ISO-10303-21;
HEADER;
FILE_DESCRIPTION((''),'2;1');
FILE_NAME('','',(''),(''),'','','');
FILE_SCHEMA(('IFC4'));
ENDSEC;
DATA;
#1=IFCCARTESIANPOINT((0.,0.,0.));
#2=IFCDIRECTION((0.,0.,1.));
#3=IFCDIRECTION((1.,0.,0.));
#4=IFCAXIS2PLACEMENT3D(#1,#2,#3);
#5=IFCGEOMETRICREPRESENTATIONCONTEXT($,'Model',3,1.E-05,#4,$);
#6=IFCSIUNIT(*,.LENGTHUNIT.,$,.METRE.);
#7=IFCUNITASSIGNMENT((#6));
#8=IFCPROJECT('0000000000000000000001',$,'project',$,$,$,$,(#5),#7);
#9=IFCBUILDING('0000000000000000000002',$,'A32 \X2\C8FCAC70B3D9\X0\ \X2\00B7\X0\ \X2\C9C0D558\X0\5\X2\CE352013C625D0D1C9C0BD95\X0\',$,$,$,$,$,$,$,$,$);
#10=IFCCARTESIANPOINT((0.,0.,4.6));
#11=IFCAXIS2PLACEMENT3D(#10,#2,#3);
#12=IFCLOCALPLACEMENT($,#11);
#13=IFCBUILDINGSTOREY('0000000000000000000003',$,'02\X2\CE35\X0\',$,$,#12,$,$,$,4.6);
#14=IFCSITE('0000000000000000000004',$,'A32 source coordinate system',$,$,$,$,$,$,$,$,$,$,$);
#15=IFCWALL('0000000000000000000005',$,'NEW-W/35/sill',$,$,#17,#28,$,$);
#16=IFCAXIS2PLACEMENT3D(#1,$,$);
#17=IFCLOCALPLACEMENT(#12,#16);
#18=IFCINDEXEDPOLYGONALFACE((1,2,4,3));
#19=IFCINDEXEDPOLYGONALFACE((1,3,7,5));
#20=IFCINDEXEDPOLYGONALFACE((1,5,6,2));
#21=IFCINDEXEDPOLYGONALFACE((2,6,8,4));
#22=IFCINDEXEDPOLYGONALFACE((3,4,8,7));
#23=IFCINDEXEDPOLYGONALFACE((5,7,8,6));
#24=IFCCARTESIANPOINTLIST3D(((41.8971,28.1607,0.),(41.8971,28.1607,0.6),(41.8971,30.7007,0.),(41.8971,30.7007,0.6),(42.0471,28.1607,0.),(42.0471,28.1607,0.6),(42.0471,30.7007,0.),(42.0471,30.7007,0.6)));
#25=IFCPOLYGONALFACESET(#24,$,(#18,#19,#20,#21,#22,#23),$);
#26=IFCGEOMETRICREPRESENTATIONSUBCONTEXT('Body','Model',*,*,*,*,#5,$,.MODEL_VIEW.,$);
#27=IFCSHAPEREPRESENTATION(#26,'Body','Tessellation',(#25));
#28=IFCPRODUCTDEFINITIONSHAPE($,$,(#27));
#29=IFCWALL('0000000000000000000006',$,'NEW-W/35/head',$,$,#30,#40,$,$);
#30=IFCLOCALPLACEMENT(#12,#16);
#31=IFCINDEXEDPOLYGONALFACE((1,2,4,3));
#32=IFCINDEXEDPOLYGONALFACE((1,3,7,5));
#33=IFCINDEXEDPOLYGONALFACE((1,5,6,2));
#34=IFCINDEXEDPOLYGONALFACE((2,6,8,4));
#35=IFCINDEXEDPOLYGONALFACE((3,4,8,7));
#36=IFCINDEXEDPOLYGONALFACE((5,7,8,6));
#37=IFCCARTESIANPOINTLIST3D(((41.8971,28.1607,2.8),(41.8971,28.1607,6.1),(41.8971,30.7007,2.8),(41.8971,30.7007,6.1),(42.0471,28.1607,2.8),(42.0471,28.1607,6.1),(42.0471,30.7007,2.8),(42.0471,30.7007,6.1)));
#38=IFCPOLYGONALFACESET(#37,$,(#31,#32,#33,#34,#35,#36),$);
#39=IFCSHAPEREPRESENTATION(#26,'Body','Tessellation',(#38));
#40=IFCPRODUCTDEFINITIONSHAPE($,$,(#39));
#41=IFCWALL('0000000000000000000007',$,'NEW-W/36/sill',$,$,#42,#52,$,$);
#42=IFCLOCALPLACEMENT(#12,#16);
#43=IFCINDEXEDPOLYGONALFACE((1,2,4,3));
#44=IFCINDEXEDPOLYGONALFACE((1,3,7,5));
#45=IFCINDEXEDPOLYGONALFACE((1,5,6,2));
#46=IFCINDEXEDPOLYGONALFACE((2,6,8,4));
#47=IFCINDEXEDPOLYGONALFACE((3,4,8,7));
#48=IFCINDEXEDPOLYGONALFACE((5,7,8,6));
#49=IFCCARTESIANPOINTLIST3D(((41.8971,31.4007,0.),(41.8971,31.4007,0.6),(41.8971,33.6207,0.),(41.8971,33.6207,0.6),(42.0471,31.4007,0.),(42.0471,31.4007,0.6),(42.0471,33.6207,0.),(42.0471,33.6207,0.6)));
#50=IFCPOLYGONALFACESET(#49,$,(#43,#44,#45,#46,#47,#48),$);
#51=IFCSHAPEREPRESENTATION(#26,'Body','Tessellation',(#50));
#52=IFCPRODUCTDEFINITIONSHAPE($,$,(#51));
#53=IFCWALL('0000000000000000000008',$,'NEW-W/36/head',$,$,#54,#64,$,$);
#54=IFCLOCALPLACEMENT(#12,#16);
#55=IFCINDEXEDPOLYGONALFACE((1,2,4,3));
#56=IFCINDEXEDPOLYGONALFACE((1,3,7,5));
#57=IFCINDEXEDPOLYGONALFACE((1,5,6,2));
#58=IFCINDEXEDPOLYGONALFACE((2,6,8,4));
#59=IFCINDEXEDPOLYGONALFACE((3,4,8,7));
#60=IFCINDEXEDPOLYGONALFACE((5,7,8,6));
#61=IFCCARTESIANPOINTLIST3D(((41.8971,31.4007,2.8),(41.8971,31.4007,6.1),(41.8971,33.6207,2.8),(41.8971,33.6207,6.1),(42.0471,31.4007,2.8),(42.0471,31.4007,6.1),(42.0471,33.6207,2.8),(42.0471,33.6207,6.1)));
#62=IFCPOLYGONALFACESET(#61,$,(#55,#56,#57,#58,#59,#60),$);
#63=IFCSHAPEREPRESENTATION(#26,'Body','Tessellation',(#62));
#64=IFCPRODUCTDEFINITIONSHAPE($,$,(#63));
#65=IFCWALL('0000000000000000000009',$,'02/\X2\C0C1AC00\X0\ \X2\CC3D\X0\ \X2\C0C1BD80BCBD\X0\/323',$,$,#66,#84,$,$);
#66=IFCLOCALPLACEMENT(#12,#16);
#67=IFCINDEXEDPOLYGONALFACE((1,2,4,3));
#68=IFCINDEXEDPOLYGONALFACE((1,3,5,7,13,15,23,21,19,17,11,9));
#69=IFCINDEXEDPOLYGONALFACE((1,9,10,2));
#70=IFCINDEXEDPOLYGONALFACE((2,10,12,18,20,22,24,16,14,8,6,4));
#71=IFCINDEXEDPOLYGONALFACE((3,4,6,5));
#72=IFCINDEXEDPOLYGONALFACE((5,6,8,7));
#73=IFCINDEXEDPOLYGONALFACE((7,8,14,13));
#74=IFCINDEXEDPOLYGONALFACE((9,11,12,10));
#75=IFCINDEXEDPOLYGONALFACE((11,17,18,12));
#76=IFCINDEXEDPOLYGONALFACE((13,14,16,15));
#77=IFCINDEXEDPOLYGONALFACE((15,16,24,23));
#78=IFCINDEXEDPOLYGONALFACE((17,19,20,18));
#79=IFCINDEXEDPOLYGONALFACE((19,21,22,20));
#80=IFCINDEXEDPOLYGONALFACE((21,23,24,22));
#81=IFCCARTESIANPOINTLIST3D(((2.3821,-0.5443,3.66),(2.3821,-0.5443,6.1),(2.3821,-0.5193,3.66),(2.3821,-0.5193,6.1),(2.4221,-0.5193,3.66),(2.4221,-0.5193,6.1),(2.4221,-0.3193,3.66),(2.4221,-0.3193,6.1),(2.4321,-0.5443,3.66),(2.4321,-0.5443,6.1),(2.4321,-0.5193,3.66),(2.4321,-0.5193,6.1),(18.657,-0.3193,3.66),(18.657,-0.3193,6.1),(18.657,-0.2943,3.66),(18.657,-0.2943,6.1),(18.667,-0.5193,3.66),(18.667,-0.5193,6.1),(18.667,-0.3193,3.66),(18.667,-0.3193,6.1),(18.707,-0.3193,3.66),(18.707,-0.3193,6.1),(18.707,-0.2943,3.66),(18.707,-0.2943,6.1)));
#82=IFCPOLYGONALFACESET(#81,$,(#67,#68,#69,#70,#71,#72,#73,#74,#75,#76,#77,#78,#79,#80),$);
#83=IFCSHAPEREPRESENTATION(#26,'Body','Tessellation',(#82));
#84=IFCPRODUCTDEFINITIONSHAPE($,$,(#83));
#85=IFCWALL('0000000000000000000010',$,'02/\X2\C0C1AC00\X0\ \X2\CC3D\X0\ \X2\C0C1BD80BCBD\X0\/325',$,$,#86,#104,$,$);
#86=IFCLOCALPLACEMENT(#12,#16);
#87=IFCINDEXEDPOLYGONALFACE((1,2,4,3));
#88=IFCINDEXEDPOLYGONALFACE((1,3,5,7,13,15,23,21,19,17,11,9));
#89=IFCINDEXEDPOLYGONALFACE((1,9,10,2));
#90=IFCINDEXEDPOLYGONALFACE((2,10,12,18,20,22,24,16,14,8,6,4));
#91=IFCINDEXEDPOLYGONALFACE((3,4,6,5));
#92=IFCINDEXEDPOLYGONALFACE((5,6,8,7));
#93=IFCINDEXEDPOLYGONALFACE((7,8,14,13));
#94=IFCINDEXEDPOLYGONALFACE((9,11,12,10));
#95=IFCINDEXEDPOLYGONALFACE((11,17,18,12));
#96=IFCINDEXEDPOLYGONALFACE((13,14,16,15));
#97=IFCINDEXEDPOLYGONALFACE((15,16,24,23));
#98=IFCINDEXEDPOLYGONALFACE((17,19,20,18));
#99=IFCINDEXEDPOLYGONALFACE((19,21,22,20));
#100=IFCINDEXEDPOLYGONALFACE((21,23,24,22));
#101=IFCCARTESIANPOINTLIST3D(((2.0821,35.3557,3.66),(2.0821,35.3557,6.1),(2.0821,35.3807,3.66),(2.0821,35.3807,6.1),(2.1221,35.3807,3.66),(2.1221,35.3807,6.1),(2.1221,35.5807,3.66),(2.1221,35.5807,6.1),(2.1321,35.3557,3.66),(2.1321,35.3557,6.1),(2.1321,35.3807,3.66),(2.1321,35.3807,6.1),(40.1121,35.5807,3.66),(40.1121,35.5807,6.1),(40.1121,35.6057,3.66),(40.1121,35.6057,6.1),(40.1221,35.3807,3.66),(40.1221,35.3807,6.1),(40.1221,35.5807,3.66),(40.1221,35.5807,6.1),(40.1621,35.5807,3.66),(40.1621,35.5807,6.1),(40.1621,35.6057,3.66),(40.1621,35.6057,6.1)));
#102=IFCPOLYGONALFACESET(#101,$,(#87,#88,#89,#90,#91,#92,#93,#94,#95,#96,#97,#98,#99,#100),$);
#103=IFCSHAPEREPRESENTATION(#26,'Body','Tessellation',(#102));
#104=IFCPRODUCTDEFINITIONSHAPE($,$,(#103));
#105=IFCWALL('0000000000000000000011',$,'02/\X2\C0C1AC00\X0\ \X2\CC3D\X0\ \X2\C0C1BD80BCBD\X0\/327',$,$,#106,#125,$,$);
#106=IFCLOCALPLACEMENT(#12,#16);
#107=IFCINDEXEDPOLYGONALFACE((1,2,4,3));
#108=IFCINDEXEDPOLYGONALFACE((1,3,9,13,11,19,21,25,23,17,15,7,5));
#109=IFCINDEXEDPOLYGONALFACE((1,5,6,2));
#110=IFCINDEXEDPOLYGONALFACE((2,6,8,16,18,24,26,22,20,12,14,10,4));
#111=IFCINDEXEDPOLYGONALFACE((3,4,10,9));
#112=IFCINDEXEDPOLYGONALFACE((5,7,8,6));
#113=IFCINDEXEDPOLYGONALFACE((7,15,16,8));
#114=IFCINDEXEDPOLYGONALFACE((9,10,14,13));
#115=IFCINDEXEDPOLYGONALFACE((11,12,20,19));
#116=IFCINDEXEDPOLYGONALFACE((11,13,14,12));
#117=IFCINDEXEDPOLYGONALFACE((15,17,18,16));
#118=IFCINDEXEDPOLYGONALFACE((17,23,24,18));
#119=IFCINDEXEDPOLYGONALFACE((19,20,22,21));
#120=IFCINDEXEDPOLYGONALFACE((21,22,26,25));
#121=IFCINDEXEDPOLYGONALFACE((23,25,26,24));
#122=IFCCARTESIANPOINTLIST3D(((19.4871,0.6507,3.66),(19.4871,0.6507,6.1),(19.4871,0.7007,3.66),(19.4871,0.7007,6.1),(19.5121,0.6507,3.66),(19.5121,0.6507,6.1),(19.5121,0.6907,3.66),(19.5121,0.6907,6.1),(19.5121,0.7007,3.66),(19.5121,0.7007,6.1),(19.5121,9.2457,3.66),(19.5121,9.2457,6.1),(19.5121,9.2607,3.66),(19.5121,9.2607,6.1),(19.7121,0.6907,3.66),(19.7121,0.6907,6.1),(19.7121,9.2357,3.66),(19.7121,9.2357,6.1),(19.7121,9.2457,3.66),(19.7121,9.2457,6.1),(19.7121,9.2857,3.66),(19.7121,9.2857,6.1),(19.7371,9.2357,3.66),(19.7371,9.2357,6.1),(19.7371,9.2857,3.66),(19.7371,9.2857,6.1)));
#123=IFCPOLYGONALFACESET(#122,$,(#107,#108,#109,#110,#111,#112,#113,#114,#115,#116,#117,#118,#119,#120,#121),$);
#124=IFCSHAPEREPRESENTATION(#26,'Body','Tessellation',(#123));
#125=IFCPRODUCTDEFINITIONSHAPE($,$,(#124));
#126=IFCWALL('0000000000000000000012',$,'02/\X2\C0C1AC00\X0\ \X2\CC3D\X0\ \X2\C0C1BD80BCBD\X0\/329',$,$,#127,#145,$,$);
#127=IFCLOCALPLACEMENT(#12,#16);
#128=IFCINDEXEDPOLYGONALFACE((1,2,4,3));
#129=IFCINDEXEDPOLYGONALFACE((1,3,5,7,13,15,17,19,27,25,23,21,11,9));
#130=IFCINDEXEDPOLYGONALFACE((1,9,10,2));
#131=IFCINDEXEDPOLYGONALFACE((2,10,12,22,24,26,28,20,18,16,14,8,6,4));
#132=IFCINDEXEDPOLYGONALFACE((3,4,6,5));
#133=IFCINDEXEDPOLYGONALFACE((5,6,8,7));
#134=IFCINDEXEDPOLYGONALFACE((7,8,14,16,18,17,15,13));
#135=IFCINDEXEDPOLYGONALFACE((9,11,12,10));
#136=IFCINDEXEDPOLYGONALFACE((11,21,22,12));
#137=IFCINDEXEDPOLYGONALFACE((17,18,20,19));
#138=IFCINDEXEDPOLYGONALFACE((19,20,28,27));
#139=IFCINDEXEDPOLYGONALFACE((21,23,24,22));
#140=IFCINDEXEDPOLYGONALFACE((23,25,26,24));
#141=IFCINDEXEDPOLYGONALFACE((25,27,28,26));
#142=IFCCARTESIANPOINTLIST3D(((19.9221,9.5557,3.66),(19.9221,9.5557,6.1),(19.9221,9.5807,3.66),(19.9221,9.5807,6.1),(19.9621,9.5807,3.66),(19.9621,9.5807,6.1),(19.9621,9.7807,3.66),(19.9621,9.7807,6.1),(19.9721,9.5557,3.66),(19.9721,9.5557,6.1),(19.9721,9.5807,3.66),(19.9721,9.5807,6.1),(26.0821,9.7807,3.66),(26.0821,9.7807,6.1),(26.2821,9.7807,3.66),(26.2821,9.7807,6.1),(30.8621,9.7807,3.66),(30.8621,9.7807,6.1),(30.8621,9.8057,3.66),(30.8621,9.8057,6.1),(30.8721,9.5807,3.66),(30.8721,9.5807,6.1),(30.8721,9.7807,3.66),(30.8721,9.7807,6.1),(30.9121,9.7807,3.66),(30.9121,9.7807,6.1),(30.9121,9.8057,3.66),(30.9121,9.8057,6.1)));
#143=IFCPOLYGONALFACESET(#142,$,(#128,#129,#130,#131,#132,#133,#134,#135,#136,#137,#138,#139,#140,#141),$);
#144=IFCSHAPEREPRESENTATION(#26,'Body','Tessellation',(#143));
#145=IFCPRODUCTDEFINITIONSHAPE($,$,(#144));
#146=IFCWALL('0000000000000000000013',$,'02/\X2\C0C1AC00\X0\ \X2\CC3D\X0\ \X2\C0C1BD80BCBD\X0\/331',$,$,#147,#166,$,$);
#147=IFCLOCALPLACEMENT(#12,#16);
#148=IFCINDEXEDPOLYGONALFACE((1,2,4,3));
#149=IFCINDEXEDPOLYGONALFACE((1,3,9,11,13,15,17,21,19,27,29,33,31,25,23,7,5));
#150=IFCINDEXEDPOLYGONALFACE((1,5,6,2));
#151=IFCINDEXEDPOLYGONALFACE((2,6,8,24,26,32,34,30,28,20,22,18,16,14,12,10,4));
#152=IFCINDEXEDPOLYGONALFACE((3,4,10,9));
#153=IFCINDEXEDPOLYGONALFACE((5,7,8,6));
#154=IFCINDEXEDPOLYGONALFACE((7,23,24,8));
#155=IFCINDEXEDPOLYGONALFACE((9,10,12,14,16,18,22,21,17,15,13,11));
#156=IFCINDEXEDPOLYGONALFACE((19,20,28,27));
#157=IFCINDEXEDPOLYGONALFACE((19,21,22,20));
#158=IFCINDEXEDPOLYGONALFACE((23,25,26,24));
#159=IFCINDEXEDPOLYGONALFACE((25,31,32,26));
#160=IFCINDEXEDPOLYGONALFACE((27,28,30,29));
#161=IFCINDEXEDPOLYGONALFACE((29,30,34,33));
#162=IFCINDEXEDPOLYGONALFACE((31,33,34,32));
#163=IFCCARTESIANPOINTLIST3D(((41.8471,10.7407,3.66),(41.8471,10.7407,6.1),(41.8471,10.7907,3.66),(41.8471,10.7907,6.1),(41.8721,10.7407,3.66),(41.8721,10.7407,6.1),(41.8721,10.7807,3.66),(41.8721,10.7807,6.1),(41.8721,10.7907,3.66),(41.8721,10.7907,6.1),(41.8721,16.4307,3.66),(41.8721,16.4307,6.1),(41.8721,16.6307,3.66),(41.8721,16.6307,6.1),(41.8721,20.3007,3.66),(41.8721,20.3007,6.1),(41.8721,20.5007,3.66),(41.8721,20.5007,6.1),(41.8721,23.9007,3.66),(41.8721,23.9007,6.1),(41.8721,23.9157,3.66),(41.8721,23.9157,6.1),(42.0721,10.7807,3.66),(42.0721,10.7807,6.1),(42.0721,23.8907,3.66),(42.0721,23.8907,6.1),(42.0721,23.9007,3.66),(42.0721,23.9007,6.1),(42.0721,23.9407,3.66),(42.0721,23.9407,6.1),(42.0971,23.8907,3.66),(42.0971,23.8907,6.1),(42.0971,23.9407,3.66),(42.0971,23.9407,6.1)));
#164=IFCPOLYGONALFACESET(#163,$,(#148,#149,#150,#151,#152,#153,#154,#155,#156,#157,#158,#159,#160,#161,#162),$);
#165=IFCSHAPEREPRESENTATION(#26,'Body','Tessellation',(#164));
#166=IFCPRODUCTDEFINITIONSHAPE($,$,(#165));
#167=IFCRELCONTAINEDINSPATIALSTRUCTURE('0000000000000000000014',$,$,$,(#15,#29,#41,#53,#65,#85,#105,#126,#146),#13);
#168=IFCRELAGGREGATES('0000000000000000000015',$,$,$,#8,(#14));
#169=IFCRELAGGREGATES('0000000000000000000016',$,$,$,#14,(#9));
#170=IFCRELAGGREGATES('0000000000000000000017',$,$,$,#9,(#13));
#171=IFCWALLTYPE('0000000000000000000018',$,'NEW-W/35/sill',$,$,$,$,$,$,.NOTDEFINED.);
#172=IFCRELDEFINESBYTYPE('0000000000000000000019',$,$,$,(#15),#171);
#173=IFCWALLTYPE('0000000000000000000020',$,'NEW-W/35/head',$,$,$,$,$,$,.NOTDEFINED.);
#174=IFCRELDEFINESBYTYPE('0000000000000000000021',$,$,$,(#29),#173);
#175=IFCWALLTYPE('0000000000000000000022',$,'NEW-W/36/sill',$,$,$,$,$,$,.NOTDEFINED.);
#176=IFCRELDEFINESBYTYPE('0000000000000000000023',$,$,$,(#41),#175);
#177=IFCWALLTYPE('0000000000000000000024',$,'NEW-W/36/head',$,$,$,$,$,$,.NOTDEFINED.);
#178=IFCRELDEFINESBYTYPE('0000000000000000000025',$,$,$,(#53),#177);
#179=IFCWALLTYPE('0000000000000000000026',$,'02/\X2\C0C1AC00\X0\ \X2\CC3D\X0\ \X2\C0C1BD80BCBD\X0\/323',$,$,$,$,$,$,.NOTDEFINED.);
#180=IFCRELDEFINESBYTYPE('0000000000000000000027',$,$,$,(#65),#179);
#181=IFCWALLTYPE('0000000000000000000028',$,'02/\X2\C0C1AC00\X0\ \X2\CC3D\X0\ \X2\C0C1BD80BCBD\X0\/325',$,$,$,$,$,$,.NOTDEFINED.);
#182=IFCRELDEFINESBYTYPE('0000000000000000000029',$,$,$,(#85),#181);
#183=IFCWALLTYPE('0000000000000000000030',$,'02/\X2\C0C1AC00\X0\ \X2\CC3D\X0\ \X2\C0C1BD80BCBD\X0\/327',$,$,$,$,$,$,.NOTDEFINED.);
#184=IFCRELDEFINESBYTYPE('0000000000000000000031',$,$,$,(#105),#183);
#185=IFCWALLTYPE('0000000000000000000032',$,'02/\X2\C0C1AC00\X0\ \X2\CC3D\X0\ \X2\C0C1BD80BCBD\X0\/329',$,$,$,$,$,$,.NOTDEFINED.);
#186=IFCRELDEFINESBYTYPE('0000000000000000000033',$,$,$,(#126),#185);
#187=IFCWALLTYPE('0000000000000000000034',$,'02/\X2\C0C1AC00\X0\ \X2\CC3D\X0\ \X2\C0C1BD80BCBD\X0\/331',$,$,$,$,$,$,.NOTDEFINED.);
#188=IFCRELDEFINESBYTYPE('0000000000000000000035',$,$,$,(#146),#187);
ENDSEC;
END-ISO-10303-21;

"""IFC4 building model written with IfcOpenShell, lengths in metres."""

from ifc_helpers import new_model, si_unit, frame, origin, origin_with_axes, place, context, subcontext, project, spatial, polyline, outline, extrude, source, transform, mapped, type_object, type_shapes, element, save


model = new_model("IFC4")

# Units and contexts
model_context = context("Model", 3, precision=1e-05, world=origin_with_axes())
body_context = subcontext(model_context, "Body", "Model", "MODEL_VIEW")
ifc_project = project(units=[si_unit("LENGTHUNIT", "METRE")], contexts=[model_context])

# Site, building, storey
site = spatial("IfcSite", under=ifc_project, Name="A32 source coordinate system")
building = spatial("IfcBuilding", under=site, Name="A32 주거동 · 지하5층–옥탑지붕")
storey_placement = place(None, frame((0.0, 0.0, 4.6), z_axis=(0.0, 0.0, 1.0), x_axis=(1.0, 0.0, 0.0)))
storey = spatial("IfcBuildingStorey", under=building, at=storey_placement, Name="02층", Elevation=4.6)

# Walls
wall_type_1 = type_object("IfcWallType", Name="NEW-W/35/sill", PredefinedType="NOTDEFINED")
shared_shape_1 = source(origin(), body_context, "Body", "SweptSolid", [
    extrude(outline(polyline([(41.8971, 28.1607), (41.8971, 30.7007), (42.0471, 30.7007), (42.0471, 28.1607), (41.8971, 28.1607)])), origin(), (0.0, 0.0, 1.0), 0.6),
])
type_shapes(wall_type_1, [shared_shape_1])
wall_1_placement = place(storey_placement, origin_with_axes())
element("IfcWall", 1, at=wall_1_placement, inside=storey, type_object=wall_type_1, Name="NEW-W/35/sill", context=body_context, shape_type="MappedRepresentation", body=[
    mapped(shared_shape_1, transform((0.0, 0.0, 0.0), scale=1.0)),
])
wall_type_2 = type_object("IfcWallType", Name="NEW-W/35/head", PredefinedType="NOTDEFINED")
shared_shape_2 = source(origin(), body_context, "Body", "SweptSolid", [
    extrude(outline(polyline([(41.8971, 28.1607), (41.8971, 30.7007), (42.0471, 30.7007), (42.0471, 28.1607), (41.8971, 28.1607)])), frame((0.0, 0.0, 2.8)), (0.0, 0.0, 1.0), 3.3),
])
type_shapes(wall_type_2, [shared_shape_2])
wall_2_placement = place(storey_placement, origin_with_axes())
element("IfcWall", 2, at=wall_2_placement, inside=storey, type_object=wall_type_2, Name="NEW-W/35/head", context=body_context, shape_type="MappedRepresentation", body=[
    mapped(shared_shape_2, transform((0.0, 0.0, 0.0), scale=1.0)),
])
wall_type_3 = type_object("IfcWallType", Name="NEW-W/36/sill", PredefinedType="NOTDEFINED")
shared_shape_3 = source(origin(), body_context, "Body", "SweptSolid", [
    extrude(outline(polyline([(41.8971, 31.4007), (41.8971, 33.6207), (42.0471, 33.6207), (42.0471, 31.4007), (41.8971, 31.4007)])), origin(), (0.0, 0.0, 1.0), 0.6),
])
type_shapes(wall_type_3, [shared_shape_3])
wall_3_placement = place(storey_placement, origin_with_axes())
element("IfcWall", 3, at=wall_3_placement, inside=storey, type_object=wall_type_3, Name="NEW-W/36/sill", context=body_context, shape_type="MappedRepresentation", body=[
    mapped(shared_shape_3, transform((0.0, 0.0, 0.0), scale=1.0)),
])
wall_type_4 = type_object("IfcWallType", Name="NEW-W/36/head", PredefinedType="NOTDEFINED")
shared_shape_4 = source(origin(), body_context, "Body", "SweptSolid", [
    extrude(outline(polyline([(41.8971, 31.4007), (41.8971, 33.6207), (42.0471, 33.6207), (42.0471, 31.4007), (41.8971, 31.4007)])), frame((0.0, 0.0, 2.8)), (0.0, 0.0, 1.0), 3.3),
])
type_shapes(wall_type_4, [shared_shape_4])
wall_4_placement = place(storey_placement, origin_with_axes())
element("IfcWall", 4, at=wall_4_placement, inside=storey, type_object=wall_type_4, Name="NEW-W/36/head", context=body_context, shape_type="MappedRepresentation", body=[
    mapped(shared_shape_4, transform((0.0, 0.0, 0.0), scale=1.0)),
])
wall_type_5 = type_object("IfcWallType", Name="02/상가 창 상부벽/323", PredefinedType="NOTDEFINED")
shared_shape_5 = source(origin(), body_context, "Body", "SweptSolid", [
    extrude(outline(polyline([(2.3821, -0.5193), (2.4221, -0.5193), (2.4221, -0.3193), (2.4071, -0.3193), (2.4071, -0.3193), (18.657, -0.3193), (18.657, -0.2943), (18.707, -0.2943), (18.707, -0.3193), (18.667, -0.3193), (18.667, -0.5193), (2.4321, -0.5193), (2.4321, -0.5443), (2.3821, -0.5443), (2.3821, -0.5193)])), frame((0.0, 0.0, 3.66)), (0.0, 0.0, 1.0), 2.44),
])
type_shapes(wall_type_5, [shared_shape_5])
wall_5_placement = place(storey_placement, origin_with_axes())
element("IfcWall", 5, at=wall_5_placement, inside=storey, type_object=wall_type_5, Name="02/상가 창 상부벽/323", context=body_context, shape_type="MappedRepresentation", body=[
    mapped(shared_shape_5, transform((0.0, 0.0, 0.0), scale=1.0)),
])
wall_type_6 = type_object("IfcWallType", Name="02/상가 창 상부벽/325", PredefinedType="NOTDEFINED")
shared_shape_6 = source(origin(), body_context, "Body", "SweptSolid", [
    extrude(outline(polyline([(2.0821, 35.3807), (2.1221, 35.3807), (2.1221, 35.5807), (2.1071, 35.5807), (2.1071, 35.5807), (40.1121, 35.5807), (40.1121, 35.6057), (40.1621, 35.6057), (40.1621, 35.5807), (40.1221, 35.5807), (40.1221, 35.3807), (2.1321, 35.3807), (2.1321, 35.3557), (2.0821, 35.3557), (2.0821, 35.3807)])), frame((0.0, 0.0, 3.66)), (0.0, 0.0, 1.0), 2.44),
])
type_shapes(wall_type_6, [shared_shape_6])
wall_6_placement = place(storey_placement, origin_with_axes())
element("IfcWall", 6, at=wall_6_placement, inside=storey, type_object=wall_type_6, Name="02/상가 창 상부벽/325", context=body_context, shape_type="MappedRepresentation", body=[
    mapped(shared_shape_6, transform((0.0, 0.0, 0.0), scale=1.0)),
])
wall_type_7 = type_object("IfcWallType", Name="02/상가 창 상부벽/327", PredefinedType="NOTDEFINED")
shared_shape_7 = source(origin(), body_context, "Body", "SweptSolid", [
    extrude(outline(polyline([(19.4871, 0.7007), (19.5121, 0.7007), (19.5121, 9.2607), (19.5121, 9.2607), (19.5121, 9.2457), (19.7121, 9.2457), (19.7121, 9.2857), (19.7371, 9.2857), (19.7371, 9.2357), (19.7121, 9.2357), (19.7121, 0.6907), (19.5121, 0.6907), (19.5121, 0.6507), (19.4871, 0.6507), (19.4871, 0.7007)])), frame((0.0, 0.0, 3.66)), (0.0, 0.0, 1.0), 2.44),
])
type_shapes(wall_type_7, [shared_shape_7])
wall_7_placement = place(storey_placement, origin_with_axes())
element("IfcWall", 7, at=wall_7_placement, inside=storey, type_object=wall_type_7, Name="02/상가 창 상부벽/327", context=body_context, shape_type="MappedRepresentation", body=[
    mapped(shared_shape_7, transform((0.0, 0.0, 0.0), scale=1.0)),
])
wall_type_8 = type_object("IfcWallType", Name="02/상가 창 상부벽/329", PredefinedType="NOTDEFINED")
shared_shape_8 = source(origin(), body_context, "Body", "SweptSolid", [
    extrude(outline(polyline([(19.9221, 9.5807), (19.9621, 9.5807), (19.9621, 9.7807), (19.9471, 9.7807), (19.9471, 9.7807), (26.0821, 9.7807), (26.0821, 9.7807), (26.2821, 9.7807), (26.2821, 9.7807), (30.8621, 9.7807), (30.8621, 9.8057), (30.9121, 9.8057), (30.9121, 9.7807), (30.8721, 9.7807), (30.8721, 9.5807), (19.9721, 9.5807), (19.9721, 9.5557), (19.9221, 9.5557), (19.9221, 9.5807)])), frame((0.0, 0.0, 3.66)), (0.0, 0.0, 1.0), 2.44),
])
type_shapes(wall_type_8, [shared_shape_8])
wall_8_placement = place(storey_placement, origin_with_axes())
element("IfcWall", 8, at=wall_8_placement, inside=storey, type_object=wall_type_8, Name="02/상가 창 상부벽/329", context=body_context, shape_type="MappedRepresentation", body=[
    mapped(shared_shape_8, transform((0.0, 0.0, 0.0), scale=1.0)),
])
wall_type_9 = type_object("IfcWallType", Name="02/상가 창 상부벽/331", PredefinedType="NOTDEFINED")
shared_shape_9 = source(origin(), body_context, "Body", "SweptSolid", [
    extrude(outline(polyline([(41.8471, 10.7907), (41.8721, 10.7907), (41.8721, 16.4307), (41.8721, 16.4307), (41.8721, 16.6307), (41.8721, 16.6307), (41.8721, 20.3007), (41.8721, 20.3007), (41.8721, 20.5007), (41.8721, 20.5007), (41.8721, 23.9157), (41.8721, 23.9157), (41.8721, 23.9007), (42.0721, 23.9007), (42.0721, 23.9407), (42.0971, 23.9407), (42.0971, 23.8907), (42.0721, 23.8907), (42.0721, 10.7807), (41.8721, 10.7807), (41.8721, 10.7407), (41.8471, 10.7407), (41.8471, 10.7907)])), frame((0.0, 0.0, 3.66)), (0.0, 0.0, 1.0), 2.44),
])
type_shapes(wall_type_9, [shared_shape_9])
wall_9_placement = place(storey_placement, origin_with_axes())
element("IfcWall", 9, at=wall_9_placement, inside=storey, type_object=wall_type_9, Name="02/상가 창 상부벽/331", context=body_context, shape_type="MappedRepresentation", body=[
    mapped(shared_shape_9, transform((0.0, 0.0, 0.0), scale=1.0)),
])

save(model, "model.ifc")
